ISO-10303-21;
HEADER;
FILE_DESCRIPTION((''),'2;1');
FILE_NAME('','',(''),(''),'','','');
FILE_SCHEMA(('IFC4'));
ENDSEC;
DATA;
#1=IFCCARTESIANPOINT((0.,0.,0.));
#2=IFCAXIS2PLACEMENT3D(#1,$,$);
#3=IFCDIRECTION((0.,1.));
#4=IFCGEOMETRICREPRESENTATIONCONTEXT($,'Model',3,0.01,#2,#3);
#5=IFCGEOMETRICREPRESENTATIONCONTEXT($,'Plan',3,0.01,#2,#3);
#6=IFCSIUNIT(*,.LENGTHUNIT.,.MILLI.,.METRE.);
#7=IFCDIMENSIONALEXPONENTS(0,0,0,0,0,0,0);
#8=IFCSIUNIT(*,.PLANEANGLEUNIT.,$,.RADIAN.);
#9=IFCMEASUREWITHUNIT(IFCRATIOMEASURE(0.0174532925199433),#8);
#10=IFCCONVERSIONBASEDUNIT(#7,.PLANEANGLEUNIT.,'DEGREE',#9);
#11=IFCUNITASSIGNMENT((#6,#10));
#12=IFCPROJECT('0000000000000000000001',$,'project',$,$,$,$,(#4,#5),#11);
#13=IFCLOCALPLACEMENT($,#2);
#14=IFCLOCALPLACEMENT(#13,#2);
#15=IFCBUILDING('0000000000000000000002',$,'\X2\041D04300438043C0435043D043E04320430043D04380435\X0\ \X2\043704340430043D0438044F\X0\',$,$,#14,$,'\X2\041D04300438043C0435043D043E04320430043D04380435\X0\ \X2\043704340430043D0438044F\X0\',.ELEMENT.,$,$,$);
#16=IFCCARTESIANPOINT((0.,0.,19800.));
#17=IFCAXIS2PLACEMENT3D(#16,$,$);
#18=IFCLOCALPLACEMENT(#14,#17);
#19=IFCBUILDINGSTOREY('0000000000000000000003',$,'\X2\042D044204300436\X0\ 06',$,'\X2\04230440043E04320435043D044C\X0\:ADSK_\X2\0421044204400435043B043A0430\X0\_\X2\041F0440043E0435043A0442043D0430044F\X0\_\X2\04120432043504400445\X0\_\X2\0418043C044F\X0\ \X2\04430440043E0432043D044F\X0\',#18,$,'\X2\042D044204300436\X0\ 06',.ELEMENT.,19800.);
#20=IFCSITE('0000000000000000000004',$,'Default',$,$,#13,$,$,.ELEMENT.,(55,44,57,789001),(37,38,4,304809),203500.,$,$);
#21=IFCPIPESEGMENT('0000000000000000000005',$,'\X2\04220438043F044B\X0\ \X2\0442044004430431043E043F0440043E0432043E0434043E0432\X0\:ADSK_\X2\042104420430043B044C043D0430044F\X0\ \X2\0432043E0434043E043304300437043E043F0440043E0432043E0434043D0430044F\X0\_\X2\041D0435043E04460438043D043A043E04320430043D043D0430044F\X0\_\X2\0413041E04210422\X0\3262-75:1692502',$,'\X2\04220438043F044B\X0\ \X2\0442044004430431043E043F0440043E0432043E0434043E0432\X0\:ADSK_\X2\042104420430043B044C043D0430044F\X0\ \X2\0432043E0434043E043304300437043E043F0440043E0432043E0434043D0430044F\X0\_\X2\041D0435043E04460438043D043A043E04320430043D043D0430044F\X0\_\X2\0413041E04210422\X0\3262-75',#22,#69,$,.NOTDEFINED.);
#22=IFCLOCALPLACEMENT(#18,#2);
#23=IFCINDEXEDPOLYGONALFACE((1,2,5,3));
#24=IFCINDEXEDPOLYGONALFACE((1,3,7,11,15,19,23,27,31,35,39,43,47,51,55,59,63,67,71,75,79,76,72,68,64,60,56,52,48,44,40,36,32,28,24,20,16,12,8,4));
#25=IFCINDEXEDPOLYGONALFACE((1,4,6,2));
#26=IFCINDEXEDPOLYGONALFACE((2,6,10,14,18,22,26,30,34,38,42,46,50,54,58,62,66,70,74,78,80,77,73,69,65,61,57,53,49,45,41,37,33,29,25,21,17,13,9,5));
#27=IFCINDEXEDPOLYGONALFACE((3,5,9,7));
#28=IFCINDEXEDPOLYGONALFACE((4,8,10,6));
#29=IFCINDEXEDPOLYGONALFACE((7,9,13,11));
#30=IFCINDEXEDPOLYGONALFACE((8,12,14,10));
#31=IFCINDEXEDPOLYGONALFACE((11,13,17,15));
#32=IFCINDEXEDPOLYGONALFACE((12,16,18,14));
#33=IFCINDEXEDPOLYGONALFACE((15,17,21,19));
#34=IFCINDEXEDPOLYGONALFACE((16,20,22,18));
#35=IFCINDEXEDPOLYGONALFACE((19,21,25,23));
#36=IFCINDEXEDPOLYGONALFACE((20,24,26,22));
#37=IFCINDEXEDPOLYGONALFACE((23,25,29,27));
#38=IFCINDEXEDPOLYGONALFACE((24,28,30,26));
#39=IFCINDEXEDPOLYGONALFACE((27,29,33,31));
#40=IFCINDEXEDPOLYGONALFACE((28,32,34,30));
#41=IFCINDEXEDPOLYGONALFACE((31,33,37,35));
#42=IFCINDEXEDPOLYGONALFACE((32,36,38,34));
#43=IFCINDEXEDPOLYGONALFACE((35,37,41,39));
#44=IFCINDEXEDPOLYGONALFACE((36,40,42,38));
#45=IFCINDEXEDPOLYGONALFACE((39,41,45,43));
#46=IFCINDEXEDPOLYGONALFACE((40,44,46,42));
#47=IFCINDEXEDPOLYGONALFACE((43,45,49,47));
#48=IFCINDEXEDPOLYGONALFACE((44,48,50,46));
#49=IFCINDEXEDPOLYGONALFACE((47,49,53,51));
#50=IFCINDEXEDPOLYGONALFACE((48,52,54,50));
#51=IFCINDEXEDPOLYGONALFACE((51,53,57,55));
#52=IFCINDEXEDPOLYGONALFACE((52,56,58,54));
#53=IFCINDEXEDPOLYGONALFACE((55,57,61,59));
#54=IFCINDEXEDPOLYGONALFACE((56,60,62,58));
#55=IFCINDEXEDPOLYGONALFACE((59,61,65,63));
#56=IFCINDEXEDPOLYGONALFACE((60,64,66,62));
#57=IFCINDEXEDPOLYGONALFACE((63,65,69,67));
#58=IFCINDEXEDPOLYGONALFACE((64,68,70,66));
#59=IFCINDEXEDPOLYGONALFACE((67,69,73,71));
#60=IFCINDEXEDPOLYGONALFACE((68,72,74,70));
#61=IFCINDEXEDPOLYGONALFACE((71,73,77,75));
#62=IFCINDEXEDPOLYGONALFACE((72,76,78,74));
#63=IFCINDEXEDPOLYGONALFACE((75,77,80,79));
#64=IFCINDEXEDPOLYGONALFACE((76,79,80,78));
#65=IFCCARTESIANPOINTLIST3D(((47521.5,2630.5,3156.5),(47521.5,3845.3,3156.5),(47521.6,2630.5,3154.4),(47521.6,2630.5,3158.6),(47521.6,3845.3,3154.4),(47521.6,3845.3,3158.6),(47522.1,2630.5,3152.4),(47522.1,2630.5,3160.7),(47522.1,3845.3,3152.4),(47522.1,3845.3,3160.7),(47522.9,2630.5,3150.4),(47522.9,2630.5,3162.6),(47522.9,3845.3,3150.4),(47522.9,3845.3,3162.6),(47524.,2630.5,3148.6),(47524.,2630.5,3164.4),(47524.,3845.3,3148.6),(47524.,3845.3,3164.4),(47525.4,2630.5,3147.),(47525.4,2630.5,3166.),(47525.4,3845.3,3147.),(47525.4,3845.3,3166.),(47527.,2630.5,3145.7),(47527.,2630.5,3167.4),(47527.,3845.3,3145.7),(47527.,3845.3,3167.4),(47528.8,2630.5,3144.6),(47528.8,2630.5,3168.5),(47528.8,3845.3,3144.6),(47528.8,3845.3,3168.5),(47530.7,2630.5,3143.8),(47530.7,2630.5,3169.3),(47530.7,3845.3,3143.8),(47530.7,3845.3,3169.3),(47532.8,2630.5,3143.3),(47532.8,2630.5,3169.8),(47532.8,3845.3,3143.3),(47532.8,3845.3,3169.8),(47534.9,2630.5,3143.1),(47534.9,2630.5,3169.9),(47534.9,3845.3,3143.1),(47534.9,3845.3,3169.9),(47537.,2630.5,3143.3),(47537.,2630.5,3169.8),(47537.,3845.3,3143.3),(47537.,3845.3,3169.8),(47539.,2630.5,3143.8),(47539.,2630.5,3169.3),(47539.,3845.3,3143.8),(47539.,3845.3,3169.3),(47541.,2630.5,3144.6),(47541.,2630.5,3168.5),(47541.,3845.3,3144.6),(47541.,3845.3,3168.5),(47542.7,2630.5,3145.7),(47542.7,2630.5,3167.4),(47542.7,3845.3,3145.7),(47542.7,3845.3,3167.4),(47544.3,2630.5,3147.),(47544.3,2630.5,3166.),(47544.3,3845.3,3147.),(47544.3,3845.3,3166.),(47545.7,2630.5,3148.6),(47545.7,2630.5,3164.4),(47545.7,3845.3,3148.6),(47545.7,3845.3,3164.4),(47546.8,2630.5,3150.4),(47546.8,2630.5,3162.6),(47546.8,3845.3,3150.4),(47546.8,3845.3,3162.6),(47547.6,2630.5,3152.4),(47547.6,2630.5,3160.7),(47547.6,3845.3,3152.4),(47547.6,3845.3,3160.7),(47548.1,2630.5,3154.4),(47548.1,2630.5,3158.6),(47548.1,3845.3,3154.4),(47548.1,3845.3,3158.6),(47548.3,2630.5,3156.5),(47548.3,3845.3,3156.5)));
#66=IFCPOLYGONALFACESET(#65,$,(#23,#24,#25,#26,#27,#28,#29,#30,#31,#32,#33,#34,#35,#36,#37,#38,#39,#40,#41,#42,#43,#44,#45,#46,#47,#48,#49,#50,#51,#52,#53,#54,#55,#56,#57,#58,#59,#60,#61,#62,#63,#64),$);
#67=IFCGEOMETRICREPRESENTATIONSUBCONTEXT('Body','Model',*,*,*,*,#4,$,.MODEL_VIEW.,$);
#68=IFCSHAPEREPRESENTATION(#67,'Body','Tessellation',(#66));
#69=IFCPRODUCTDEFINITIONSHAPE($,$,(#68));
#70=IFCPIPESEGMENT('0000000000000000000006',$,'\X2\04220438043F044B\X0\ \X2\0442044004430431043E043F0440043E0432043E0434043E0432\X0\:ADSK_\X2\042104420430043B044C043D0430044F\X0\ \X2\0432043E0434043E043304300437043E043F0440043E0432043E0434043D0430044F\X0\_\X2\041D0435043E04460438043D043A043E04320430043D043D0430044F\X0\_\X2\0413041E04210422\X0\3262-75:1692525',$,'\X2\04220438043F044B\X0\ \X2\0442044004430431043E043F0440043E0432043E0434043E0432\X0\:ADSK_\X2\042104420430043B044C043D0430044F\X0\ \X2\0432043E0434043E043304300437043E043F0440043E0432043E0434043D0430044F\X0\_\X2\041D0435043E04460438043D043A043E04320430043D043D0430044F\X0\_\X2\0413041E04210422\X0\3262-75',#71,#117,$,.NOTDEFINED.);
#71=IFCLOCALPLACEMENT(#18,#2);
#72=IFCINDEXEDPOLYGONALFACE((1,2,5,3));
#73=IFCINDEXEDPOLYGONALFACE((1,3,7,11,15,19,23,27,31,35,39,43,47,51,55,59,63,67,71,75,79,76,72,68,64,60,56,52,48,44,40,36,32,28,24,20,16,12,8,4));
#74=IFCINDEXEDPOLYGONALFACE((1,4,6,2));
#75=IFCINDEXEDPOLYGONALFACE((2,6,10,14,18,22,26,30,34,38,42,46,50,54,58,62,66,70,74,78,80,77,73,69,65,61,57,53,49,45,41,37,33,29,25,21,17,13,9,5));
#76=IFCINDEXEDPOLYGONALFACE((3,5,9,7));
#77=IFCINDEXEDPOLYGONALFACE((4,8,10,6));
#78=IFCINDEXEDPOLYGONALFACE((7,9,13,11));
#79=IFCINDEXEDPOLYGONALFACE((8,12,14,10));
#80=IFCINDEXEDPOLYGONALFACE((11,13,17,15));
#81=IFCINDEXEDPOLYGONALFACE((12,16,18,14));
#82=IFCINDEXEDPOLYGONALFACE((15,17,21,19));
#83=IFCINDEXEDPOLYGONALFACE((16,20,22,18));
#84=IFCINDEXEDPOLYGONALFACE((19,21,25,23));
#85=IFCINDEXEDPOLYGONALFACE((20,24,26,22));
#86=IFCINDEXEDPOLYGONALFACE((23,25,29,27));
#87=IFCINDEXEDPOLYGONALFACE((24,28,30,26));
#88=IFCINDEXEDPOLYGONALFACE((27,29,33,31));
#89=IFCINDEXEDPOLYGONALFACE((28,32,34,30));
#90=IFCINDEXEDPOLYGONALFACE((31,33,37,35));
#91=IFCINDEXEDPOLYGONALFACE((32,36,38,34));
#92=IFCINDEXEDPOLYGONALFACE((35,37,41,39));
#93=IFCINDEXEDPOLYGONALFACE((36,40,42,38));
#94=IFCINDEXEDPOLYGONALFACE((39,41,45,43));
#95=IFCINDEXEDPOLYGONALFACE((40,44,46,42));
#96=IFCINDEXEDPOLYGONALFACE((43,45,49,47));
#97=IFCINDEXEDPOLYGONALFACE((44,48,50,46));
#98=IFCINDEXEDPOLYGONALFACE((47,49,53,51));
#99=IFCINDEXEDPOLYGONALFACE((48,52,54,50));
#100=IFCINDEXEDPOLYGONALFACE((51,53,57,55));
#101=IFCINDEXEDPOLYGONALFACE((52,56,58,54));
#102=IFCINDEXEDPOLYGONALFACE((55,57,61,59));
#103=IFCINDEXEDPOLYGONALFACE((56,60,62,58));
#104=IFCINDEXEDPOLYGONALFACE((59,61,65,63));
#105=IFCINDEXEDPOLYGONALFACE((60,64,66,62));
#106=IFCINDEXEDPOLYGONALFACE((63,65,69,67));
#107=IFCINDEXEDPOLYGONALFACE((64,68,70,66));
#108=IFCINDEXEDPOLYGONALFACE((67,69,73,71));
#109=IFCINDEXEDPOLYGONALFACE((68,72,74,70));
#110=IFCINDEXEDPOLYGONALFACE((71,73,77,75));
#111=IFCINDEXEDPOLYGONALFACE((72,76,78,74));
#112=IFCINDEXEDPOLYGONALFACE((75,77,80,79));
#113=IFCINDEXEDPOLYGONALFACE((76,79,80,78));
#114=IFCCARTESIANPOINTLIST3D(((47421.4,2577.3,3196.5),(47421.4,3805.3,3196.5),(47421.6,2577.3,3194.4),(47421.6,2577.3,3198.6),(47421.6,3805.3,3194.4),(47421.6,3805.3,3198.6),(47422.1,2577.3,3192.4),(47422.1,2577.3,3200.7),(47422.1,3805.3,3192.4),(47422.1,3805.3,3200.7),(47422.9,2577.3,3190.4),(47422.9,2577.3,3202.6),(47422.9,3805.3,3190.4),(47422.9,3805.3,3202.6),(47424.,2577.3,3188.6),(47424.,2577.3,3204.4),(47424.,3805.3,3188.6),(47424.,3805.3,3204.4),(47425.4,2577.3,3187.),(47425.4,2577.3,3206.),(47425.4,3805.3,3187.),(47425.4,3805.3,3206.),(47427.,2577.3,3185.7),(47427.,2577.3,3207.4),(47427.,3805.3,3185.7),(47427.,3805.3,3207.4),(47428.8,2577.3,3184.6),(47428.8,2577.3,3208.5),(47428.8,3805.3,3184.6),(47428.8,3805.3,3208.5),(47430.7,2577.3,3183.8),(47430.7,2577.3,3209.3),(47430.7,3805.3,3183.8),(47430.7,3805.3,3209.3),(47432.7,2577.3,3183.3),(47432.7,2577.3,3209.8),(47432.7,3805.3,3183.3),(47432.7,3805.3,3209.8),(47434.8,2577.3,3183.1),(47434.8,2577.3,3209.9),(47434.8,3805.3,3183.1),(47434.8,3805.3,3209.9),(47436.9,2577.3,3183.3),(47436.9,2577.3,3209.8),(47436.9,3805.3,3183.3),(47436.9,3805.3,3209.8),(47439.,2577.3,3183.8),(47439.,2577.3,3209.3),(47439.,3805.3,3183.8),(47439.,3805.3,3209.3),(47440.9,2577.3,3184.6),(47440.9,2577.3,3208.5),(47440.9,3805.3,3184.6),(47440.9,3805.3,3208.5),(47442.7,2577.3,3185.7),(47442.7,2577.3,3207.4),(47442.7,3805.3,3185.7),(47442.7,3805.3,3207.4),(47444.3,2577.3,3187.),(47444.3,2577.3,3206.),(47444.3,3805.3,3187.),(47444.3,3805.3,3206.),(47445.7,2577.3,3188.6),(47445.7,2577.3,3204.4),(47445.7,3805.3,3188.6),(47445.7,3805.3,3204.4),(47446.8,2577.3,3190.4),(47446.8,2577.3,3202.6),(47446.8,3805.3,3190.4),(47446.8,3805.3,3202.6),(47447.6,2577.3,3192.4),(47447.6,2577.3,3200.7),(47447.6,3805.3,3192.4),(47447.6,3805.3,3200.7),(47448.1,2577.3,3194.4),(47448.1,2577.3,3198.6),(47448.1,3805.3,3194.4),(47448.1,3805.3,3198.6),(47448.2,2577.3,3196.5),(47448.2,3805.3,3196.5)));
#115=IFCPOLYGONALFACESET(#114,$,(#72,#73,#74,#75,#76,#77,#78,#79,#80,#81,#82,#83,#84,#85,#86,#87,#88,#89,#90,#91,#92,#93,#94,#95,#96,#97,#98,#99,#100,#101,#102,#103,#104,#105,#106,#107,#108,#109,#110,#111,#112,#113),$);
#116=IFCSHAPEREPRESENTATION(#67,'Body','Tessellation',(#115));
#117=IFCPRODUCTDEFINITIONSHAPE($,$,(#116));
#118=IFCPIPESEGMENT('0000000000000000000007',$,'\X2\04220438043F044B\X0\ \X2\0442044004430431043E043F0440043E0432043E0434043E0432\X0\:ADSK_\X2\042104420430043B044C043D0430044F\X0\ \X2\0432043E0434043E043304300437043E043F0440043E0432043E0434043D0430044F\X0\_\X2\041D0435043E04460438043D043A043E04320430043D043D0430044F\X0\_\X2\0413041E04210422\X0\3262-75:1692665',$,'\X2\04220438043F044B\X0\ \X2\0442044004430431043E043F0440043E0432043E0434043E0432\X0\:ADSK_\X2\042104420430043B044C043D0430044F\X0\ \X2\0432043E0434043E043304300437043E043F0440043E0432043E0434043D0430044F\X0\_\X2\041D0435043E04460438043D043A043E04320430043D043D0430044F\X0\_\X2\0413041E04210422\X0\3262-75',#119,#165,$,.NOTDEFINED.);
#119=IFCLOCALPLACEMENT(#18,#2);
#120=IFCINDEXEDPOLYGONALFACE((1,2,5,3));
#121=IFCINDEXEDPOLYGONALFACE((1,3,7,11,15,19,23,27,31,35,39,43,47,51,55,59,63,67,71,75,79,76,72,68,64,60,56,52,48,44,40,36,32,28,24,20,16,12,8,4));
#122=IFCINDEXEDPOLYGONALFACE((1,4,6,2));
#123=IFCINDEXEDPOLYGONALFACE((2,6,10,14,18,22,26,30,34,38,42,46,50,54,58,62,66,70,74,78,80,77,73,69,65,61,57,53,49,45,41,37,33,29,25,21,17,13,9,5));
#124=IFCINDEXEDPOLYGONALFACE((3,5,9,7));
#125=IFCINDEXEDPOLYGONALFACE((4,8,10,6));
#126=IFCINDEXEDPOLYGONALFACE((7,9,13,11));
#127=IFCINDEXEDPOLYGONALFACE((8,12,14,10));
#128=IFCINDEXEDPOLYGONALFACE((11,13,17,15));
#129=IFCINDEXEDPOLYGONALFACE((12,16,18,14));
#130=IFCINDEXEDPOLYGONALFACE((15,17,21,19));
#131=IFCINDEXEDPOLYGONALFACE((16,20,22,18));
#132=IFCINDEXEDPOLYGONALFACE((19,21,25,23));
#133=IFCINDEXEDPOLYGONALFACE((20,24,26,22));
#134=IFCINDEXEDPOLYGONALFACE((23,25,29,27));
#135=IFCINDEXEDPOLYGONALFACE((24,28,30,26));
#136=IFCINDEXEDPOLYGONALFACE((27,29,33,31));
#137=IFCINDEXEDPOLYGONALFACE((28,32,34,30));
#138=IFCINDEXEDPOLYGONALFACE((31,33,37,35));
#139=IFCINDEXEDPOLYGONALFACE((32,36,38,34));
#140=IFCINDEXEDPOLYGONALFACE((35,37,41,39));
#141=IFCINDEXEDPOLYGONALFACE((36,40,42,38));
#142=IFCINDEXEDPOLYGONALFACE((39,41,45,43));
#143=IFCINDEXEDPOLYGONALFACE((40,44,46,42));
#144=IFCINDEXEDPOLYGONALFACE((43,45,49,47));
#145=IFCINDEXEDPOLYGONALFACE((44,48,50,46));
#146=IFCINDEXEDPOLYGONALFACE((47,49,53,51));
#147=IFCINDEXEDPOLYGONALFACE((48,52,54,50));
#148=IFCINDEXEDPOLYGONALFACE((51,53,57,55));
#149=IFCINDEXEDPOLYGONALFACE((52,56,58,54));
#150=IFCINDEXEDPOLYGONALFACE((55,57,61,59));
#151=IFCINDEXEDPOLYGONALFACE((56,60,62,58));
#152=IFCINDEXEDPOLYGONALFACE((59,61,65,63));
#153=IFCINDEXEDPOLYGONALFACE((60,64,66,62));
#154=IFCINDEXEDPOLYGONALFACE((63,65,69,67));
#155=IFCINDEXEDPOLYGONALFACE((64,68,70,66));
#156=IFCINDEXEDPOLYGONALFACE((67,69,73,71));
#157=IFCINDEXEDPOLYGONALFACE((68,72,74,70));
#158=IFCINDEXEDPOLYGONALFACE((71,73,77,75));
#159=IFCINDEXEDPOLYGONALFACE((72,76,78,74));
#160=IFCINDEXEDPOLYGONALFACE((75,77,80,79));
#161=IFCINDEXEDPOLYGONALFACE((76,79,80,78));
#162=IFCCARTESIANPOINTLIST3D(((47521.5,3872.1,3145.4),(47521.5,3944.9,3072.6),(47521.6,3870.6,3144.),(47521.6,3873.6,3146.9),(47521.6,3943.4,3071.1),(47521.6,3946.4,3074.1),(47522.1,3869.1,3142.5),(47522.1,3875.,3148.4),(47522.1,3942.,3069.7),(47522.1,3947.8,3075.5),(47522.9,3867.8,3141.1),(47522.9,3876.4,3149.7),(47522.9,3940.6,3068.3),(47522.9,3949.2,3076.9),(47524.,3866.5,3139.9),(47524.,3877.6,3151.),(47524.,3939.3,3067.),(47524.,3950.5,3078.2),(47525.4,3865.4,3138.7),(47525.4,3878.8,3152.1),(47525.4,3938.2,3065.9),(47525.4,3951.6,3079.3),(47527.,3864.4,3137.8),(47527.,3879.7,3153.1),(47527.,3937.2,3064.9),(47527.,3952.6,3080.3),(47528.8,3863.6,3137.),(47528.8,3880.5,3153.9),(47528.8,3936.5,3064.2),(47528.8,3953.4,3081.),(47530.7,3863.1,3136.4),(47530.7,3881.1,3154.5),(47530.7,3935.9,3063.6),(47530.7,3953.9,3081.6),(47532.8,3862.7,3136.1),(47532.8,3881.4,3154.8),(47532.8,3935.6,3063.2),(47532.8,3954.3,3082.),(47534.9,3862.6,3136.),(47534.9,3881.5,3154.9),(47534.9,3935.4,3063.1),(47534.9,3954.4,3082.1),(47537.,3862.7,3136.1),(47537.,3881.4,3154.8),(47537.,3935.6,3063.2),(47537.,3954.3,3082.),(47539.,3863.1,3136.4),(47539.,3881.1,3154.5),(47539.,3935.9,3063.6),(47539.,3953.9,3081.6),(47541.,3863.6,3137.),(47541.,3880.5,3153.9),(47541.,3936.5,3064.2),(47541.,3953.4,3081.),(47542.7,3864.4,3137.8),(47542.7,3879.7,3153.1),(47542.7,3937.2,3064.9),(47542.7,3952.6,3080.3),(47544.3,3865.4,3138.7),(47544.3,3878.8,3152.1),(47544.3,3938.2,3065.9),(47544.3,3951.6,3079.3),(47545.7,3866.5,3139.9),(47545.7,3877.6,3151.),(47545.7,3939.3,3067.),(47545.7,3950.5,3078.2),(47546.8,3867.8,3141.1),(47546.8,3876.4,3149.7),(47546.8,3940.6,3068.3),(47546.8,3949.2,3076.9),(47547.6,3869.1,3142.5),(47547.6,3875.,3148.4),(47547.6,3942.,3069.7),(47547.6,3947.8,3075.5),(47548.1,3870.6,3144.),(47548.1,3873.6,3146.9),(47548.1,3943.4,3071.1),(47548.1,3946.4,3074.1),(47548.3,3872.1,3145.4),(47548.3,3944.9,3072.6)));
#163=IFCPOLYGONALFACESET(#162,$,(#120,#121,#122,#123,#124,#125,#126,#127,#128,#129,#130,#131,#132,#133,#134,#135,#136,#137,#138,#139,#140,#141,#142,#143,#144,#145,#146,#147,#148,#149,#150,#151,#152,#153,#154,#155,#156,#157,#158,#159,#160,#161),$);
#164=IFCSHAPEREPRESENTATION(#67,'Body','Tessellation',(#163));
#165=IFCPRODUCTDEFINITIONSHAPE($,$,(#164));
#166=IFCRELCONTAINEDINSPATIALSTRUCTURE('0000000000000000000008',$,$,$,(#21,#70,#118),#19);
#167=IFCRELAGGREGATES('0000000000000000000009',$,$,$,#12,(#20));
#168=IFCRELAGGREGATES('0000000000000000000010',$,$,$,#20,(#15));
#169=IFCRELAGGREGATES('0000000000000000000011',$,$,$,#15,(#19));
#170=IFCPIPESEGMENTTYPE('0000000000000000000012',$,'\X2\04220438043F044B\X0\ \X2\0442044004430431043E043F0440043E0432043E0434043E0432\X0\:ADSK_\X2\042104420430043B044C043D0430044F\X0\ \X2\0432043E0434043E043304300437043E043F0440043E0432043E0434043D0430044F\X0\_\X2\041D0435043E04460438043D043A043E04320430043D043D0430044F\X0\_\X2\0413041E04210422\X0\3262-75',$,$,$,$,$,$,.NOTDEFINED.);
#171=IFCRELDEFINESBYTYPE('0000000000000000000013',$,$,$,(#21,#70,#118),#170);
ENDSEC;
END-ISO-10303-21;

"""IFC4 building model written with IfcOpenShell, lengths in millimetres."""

from ifc_helpers import new_model, entity, si_unit, converted_unit, direction, frame, origin, place, context, subcontext, project, spatial, indexed_curve, outline, extrude, type_object, element, save


model = new_model("IFC4")

# Units and contexts
model_context = context("Model", 3, precision=0.01, world=origin(), true_north=direction((0.0, 1.0)))
plan_context = context("Plan", 3, precision=0.01, world=origin(), true_north=direction((0.0, 1.0)))
body_context = subcontext(model_context, "Body", "Model", "MODEL_VIEW")
ifc_project = project(units=[si_unit("LENGTHUNIT", "METRE", prefix="MILLI"), converted_unit("PLANEANGLEUNIT", "DEGREE", entity("IfcRatioMeasure", 0.0174532925199433), si_unit("PLANEANGLEUNIT", "RADIAN"), dimensions=[0, 0, 0, 0, 0, 0, 0])], contexts=[model_context, plan_context])

# Site, building, storey
site_placement = place(None, origin())
site = spatial("IfcSite", under=ifc_project, at=site_placement, Name="Default", CompositionType="ELEMENT", RefLatitude=(55, 44, 57, 789001), RefLongitude=(37, 38, 4, 304809), RefElevation=203500.0)
building_placement = place(site_placement, origin())
building = spatial("IfcBuilding", under=site, at=building_placement, Name="Наименование здания", LongName="Наименование здания", CompositionType="ELEMENT")
storey_placement = place(building_placement, frame((0.0, 0.0, 19800.0)))
storey = spatial("IfcBuildingStorey", under=building, at=storey_placement, Name="Этаж 06", ObjectType="Уровень:ADSK_Стрелка_Проектная_Вверх_Имя уровня", LongName="Этаж 06", CompositionType="ELEMENT", Elevation=19800.0)

# Pipe segments
pipe_segment_type = type_object("IfcPipeSegmentType", Name="Типы трубопроводов:ADSK_Стальная водогазопроводная_Неоцинкованная_ГОСТ3262-75", PredefinedType="NOTDEFINED")
placement = place(storey_placement, origin())
element("IfcPipeSegment", 1, at=placement, inside=storey, type_object=pipe_segment_type, Name="Типы трубопроводов:ADSK_Стальная водогазопроводная_Неоцинкованная_ГОСТ3262-75:1692502", ObjectType="Типы трубопроводов:ADSK_Стальная водогазопроводная_Неоцинкованная_ГОСТ3262-75", PredefinedType="NOTDEFINED", context=body_context, shape_type="SweptSolid", body=[
    extrude(outline(indexed_curve([(13.4, 0.0), (13.2, 2.1), (12.7, 4.1), (11.9, 6.1), (10.8, 7.9), (9.5, 9.5), (7.9, 10.8), (6.1, 11.9), (4.1, 12.7), (2.1, 13.2), (0.0, 13.4), (-2.1, 13.2), (-4.1, 12.7), (-6.1, 11.9), (-7.9, 10.8), (-9.5, 9.5), (-10.8, 7.9), (-11.9, 6.1), (-12.7, 4.1), (-13.2, 2.1), (-13.4, 0.0), (-13.2, -2.1), (-12.7, -4.1), (-11.9, -6.1), (-10.8, -7.9), (-9.5, -9.5), (-7.9, -10.8), (-6.1, -11.9), (-4.1, -12.7), (-2.1, -13.2), (0.0, -13.4), (2.1, -13.2), (4.1, -12.7), (6.1, -11.9), (7.9, -10.8), (9.5, -9.5), (10.8, -7.9), (11.9, -6.1), (12.7, -4.1), (13.2, -2.1), (13.4, 0.0)], self_intersect=False)), frame((47534.9, 2630.5, 3156.5), z_axis=(0.0, 1.0, 0.0), x_axis=(1.0, 0.0, 0.0)), (0.0, 0.0, 1.0), 1214.8),
])
element("IfcPipeSegment", 2, at=placement, inside=storey, type_object=pipe_segment_type, Name="Типы трубопроводов:ADSK_Стальная водогазопроводная_Неоцинкованная_ГОСТ3262-75:1692525", ObjectType="Типы трубопроводов:ADSK_Стальная водогазопроводная_Неоцинкованная_ГОСТ3262-75", PredefinedType="NOTDEFINED", context=body_context, shape_type="SweptSolid", body=[
    extrude(outline(indexed_curve([(13.4, 0.0), (13.2, 2.1), (12.7, 4.1), (11.9, 6.1), (10.8, 7.9), (9.5, 9.5), (7.9, 10.8), (6.1, 11.9), (4.1, 12.7), (2.1, 13.2), (0.0, 13.4), (-2.1, 13.2), (-4.1, 12.7), (-6.1, 11.9), (-7.9, 10.8), (-9.5, 9.5), (-10.8, 7.9), (-11.9, 6.1), (-12.7, 4.1), (-13.2, 2.1), (-13.4, 0.0), (-13.2, -2.1), (-12.7, -4.1), (-11.9, -6.1), (-10.8, -7.9), (-9.5, -9.5), (-7.9, -10.8), (-6.1, -11.9), (-4.1, -12.7), (-2.1, -13.2), (0.0, -13.4), (2.1, -13.2), (4.1, -12.7), (6.1, -11.9), (7.9, -10.8), (9.5, -9.5), (10.8, -7.9), (11.9, -6.1), (12.7, -4.1), (13.2, -2.1), (13.4, 0.0)], self_intersect=False)), frame((47434.8, 2577.3, 3196.5), z_axis=(0.0, 1.0, 0.0), x_axis=(1.0, 0.0, 0.0)), (0.0, 0.0, 1.0), 1228.0),
])
element("IfcPipeSegment", 3, at=placement, inside=storey, type_object=pipe_segment_type, Name="Типы трубопроводов:ADSK_Стальная водогазопроводная_Неоцинкованная_ГОСТ3262-75:1692665", ObjectType="Типы трубопроводов:ADSK_Стальная водогазопроводная_Неоцинкованная_ГОСТ3262-75", PredefinedType="NOTDEFINED", context=body_context, shape_type="SweptSolid", body=[
    extrude(outline(indexed_curve([(13.4, 0.0), (13.2, 2.1), (12.7, 4.1), (11.9, 6.1), (10.8, 7.9), (9.5, 9.5), (7.9, 10.8), (6.1, 11.9), (4.1, 12.7), (2.1, 13.2), (0.0, 13.4), (-2.1, 13.2), (-4.1, 12.7), (-6.1, 11.9), (-7.9, 10.8), (-9.5, 9.5), (-10.8, 7.9), (-11.9, 6.1), (-12.7, 4.1), (-13.2, 2.1), (-13.4, 0.0), (-13.2, -2.1), (-12.7, -4.1), (-11.9, -6.1), (-10.8, -7.9), (-9.5, -9.5), (-7.9, -10.8), (-6.1, -11.9), (-4.1, -12.7), (-2.1, -13.2), (0.0, -13.4), (2.1, -13.2), (4.1, -12.7), (6.1, -11.9), (7.9, -10.8), (9.5, -9.5), (10.8, -7.9), (11.9, -6.1), (12.7, -4.1), (13.2, -2.1), (13.4, 0.0)], self_intersect=False)), frame((47534.9, 3944.9, 3072.6), z_axis=(0.0, -0.707107, 0.707107), x_axis=(-1.0, 0.0, 0.0)), (0.0, 0.0, 1.0), 103.0),
])

save(model, "model.ifc")
